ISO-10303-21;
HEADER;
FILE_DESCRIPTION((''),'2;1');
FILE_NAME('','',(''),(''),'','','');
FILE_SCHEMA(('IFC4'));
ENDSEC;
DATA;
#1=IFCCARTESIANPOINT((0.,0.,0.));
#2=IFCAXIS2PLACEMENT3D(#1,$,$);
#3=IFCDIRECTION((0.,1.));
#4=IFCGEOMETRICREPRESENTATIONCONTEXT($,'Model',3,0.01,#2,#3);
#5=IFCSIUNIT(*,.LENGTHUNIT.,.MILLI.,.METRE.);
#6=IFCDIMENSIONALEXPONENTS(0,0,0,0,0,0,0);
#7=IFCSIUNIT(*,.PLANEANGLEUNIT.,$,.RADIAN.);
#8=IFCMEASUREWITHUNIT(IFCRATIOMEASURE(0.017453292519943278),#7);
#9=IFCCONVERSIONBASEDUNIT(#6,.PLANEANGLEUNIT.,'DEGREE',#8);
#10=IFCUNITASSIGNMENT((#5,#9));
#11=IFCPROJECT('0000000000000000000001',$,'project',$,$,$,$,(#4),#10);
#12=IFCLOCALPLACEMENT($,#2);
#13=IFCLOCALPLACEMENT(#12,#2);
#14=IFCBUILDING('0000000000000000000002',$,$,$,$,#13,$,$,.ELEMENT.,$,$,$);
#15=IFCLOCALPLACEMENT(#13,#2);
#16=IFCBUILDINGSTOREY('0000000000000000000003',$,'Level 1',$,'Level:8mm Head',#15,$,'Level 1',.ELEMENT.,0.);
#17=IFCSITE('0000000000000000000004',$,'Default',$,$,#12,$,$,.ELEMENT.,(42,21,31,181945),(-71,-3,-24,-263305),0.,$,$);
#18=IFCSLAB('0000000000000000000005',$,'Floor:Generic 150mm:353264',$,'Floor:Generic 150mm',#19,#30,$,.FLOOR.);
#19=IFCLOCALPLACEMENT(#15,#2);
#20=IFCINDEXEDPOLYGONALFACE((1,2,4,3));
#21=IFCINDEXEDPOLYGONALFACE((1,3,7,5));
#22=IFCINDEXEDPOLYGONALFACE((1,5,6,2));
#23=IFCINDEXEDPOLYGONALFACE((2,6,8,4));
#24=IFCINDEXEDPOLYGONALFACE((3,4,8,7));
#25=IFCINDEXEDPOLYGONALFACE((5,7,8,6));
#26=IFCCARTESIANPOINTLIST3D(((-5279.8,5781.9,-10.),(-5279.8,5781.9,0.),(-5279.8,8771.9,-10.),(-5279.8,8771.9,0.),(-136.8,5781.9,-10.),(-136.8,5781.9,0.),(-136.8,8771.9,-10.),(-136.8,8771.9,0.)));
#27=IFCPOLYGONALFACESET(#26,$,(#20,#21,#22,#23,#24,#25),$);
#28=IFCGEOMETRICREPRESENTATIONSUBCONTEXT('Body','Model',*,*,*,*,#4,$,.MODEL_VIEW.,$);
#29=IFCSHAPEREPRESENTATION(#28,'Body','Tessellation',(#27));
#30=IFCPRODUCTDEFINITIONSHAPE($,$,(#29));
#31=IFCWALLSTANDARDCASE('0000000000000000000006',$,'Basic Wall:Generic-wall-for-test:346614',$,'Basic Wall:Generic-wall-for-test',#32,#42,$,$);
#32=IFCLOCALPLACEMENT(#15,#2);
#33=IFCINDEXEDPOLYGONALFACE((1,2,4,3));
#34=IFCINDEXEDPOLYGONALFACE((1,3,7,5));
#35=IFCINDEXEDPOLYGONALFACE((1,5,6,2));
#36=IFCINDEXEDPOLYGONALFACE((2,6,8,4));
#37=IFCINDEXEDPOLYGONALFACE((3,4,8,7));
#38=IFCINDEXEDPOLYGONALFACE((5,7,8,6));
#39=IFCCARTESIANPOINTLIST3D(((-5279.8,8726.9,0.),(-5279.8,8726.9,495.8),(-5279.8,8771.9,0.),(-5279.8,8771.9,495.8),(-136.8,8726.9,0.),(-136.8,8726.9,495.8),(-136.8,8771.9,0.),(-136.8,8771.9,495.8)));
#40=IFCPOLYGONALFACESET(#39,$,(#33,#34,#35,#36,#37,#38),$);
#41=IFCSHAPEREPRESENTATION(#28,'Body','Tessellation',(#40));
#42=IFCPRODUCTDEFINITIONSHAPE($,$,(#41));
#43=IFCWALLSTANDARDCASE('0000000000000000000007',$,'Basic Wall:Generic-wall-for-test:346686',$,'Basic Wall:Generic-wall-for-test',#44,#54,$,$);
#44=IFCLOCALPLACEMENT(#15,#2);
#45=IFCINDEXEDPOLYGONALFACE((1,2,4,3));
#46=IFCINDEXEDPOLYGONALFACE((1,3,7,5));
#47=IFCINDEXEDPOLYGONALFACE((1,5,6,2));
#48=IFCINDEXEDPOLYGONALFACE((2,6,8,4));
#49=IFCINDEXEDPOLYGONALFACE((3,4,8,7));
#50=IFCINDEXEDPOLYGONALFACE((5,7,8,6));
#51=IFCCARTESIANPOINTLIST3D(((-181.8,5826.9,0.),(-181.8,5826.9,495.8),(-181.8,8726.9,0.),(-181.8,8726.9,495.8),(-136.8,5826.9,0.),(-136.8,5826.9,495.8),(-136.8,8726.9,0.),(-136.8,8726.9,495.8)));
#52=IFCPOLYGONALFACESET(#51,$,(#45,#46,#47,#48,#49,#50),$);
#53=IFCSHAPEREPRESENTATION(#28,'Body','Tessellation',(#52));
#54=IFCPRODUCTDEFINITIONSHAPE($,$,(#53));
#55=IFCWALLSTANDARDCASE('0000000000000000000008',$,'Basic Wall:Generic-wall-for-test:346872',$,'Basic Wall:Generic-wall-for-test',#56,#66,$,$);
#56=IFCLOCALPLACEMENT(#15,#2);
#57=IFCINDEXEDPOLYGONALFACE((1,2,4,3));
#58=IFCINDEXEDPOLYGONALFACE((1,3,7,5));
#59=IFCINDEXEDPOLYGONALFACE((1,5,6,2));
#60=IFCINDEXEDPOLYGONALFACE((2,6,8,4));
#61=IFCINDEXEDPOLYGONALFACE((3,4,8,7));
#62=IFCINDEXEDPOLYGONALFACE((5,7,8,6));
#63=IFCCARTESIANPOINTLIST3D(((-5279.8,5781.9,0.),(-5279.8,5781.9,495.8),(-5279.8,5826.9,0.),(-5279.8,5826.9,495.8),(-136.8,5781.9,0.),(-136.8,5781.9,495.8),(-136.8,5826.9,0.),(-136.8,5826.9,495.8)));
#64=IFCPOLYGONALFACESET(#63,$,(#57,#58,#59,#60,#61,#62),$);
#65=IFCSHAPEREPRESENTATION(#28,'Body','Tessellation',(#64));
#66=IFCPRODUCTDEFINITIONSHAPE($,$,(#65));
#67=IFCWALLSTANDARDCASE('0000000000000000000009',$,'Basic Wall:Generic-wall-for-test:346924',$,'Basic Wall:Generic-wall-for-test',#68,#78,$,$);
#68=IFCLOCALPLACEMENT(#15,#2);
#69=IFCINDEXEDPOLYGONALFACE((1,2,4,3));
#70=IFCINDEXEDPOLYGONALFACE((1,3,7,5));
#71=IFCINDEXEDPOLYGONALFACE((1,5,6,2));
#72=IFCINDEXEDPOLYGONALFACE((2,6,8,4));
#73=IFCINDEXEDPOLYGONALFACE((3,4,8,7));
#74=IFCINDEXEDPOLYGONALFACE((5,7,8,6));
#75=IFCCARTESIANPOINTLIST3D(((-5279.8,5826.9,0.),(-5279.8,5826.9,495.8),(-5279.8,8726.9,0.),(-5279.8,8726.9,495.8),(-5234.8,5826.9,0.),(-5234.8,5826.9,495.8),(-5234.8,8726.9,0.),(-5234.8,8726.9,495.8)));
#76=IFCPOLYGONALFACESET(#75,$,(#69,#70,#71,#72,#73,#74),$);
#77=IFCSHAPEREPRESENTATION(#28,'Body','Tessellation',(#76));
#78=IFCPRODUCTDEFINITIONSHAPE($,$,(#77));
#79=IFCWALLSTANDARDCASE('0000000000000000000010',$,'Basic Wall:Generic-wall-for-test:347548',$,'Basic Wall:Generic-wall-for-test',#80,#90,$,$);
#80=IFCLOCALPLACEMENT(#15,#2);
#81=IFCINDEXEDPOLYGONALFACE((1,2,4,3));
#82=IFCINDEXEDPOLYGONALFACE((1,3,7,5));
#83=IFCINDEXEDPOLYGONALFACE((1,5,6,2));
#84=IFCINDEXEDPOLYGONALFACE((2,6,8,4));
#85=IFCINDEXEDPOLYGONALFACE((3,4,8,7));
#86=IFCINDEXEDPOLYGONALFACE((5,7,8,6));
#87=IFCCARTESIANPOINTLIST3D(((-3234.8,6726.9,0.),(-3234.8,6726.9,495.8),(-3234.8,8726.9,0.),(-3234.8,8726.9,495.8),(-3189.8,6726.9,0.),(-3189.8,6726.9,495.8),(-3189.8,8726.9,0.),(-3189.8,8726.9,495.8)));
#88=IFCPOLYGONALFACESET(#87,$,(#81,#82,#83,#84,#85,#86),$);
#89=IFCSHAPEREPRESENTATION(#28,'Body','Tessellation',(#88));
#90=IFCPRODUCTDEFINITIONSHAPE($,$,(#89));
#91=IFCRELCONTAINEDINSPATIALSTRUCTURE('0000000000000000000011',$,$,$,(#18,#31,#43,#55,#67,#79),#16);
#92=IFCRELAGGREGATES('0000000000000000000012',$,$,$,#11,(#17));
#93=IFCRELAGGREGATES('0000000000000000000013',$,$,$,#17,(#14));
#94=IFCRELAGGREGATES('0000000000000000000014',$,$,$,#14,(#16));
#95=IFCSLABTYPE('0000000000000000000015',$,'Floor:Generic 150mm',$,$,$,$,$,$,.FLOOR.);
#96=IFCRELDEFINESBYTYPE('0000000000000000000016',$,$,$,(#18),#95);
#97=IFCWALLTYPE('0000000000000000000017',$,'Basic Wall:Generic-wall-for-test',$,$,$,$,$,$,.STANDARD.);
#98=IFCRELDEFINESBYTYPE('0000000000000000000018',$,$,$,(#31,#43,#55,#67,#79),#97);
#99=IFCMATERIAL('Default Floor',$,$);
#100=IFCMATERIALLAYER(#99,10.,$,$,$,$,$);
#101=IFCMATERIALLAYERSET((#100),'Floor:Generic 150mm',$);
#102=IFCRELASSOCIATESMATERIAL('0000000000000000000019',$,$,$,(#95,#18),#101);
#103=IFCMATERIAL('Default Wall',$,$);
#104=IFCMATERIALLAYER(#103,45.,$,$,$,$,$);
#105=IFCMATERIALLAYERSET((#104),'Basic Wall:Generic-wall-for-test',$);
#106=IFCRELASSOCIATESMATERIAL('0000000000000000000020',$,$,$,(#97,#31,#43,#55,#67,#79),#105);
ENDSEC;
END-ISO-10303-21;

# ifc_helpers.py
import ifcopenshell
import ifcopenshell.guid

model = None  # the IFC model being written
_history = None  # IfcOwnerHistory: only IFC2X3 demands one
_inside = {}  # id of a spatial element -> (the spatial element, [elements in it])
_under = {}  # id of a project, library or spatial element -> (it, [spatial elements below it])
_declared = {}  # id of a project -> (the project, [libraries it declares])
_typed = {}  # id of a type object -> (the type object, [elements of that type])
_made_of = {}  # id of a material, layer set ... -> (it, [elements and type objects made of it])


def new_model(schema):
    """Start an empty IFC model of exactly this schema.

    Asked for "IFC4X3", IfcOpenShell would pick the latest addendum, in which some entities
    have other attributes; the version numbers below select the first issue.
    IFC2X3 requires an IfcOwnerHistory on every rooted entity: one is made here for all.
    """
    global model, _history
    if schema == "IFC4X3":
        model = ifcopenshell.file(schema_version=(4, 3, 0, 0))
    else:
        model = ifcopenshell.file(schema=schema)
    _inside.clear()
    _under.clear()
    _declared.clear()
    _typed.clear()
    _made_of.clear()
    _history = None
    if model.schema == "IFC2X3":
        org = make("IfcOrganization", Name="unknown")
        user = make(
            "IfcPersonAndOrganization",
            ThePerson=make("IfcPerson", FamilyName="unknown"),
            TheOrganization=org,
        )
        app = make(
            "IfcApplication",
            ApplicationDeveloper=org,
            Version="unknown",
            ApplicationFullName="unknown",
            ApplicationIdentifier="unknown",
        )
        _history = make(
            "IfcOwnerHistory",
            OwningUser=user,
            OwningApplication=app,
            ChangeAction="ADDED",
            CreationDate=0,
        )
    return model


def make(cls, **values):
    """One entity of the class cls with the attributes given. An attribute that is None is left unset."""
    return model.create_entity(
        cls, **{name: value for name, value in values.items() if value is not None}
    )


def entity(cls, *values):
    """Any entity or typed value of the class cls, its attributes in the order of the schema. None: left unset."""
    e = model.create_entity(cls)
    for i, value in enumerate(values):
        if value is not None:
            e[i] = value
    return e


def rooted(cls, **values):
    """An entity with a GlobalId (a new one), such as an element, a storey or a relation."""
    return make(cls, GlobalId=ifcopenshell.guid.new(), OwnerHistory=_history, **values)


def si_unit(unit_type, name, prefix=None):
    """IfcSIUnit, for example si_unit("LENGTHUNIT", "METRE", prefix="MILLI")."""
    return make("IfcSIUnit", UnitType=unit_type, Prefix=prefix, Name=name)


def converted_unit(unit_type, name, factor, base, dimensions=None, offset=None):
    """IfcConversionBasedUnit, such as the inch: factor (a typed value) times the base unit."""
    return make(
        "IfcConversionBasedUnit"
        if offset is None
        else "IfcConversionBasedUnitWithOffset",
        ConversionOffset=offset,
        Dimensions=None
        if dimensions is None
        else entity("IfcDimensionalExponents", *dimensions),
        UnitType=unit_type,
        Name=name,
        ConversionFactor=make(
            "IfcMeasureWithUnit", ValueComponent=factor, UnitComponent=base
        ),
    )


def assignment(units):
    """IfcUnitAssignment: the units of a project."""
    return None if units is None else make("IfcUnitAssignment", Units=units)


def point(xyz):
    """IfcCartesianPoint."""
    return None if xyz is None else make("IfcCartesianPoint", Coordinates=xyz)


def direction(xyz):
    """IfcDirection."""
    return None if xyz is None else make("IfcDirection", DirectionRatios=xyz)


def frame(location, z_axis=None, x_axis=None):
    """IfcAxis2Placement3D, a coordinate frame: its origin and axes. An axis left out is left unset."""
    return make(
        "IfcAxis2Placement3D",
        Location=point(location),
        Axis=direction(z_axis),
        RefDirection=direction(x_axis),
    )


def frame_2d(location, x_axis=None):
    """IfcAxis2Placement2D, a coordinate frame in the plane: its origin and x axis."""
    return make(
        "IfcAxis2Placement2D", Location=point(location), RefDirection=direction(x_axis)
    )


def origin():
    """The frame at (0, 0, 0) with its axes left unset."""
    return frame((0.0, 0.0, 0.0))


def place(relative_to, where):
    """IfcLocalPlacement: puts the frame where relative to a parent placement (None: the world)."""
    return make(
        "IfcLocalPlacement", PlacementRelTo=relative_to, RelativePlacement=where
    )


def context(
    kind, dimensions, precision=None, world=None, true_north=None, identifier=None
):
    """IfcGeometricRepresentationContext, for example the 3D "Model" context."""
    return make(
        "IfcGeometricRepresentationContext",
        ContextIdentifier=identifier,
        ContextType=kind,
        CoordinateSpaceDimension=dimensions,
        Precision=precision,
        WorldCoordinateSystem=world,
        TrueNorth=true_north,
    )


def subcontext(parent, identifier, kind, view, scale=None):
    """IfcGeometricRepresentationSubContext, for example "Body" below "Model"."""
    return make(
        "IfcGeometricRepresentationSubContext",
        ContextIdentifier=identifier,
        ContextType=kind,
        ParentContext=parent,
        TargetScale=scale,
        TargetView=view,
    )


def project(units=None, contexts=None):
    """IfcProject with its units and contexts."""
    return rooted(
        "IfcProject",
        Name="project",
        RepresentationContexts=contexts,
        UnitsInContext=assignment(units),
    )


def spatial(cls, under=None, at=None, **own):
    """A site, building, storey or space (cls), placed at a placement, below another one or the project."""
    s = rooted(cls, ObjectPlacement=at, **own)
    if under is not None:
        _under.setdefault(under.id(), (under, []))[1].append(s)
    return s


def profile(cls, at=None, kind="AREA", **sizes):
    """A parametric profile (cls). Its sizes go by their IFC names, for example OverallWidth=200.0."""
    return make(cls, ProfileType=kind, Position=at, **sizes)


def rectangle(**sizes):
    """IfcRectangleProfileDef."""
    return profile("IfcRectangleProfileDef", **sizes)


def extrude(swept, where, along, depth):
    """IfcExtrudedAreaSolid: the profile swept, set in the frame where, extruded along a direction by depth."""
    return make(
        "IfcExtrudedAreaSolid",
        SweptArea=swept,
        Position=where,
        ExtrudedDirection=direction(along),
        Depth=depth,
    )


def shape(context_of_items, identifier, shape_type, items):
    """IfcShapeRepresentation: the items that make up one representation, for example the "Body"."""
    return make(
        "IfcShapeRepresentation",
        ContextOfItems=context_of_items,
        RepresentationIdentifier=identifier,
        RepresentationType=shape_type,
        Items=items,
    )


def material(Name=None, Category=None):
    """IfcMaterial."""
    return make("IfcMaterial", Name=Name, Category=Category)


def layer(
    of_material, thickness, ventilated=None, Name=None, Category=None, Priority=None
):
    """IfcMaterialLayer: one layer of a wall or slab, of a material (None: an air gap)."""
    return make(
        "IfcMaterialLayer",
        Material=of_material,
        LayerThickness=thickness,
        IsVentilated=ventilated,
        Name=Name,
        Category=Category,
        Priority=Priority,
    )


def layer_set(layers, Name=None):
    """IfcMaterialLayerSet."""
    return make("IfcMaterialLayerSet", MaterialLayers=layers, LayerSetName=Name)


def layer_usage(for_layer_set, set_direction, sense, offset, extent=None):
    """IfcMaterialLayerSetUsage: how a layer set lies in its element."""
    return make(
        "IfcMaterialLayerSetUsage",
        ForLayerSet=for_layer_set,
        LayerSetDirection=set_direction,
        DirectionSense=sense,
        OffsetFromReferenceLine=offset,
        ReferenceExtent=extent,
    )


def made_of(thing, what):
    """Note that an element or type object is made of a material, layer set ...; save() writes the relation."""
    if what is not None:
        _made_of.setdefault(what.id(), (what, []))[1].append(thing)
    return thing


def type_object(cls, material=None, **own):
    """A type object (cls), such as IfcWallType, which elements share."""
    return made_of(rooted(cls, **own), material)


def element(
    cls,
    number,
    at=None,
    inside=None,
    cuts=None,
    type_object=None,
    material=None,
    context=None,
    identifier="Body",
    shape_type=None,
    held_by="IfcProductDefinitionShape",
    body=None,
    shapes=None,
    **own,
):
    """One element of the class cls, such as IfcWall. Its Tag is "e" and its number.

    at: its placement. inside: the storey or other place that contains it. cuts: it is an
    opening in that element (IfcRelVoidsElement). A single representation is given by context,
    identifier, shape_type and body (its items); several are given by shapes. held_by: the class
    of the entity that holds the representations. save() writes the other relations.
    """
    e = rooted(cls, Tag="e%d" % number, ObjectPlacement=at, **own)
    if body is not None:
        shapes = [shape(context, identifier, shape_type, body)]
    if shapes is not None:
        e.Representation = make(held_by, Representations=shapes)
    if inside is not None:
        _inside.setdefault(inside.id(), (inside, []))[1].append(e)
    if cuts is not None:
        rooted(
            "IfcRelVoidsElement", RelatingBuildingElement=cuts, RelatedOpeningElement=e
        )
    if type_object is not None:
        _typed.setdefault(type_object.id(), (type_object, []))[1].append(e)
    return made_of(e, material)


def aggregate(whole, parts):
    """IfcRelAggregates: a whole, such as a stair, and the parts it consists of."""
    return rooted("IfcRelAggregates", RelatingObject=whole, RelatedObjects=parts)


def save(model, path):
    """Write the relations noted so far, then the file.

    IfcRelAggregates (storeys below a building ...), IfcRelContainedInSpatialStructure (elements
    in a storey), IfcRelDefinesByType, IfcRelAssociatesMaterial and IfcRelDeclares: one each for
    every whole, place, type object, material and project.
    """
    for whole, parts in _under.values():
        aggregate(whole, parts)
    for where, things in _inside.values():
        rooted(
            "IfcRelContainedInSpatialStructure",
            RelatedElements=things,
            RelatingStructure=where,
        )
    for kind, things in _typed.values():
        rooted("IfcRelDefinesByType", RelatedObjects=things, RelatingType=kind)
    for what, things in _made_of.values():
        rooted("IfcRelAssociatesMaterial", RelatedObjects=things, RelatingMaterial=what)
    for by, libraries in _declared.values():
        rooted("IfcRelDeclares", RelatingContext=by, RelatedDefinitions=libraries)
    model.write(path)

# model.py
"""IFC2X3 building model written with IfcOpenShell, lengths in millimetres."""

from ifc_helpers import new_model, entity, si_unit, converted_unit, direction, frame, frame_2d, origin, place, context, subcontext, project, spatial, rectangle, extrude, material, layer, layer_set, layer_usage, type_object, element, save


model = new_model("IFC2X3")

# Units and contexts
model_context = context("Model", 3, precision=0.01, world=origin(), true_north=direction((0.0, 1.0)))
body_context = subcontext(model_context, "Body", "Model", "MODEL_VIEW")
ifc_project = project(units=[si_unit("LENGTHUNIT", "METRE", prefix="MILLI"), converted_unit("PLANEANGLEUNIT", "DEGREE", entity("IfcRatioMeasure", 0.017453292519943278), si_unit("PLANEANGLEUNIT", "RADIAN"), dimensions=[0, 0, 0, 0, 0, 0, 0])], contexts=[model_context])

# Site, building, storey
site_placement = place(None, origin())
site = spatial("IfcSite", under=ifc_project, at=site_placement, Name="Default", CompositionType="ELEMENT", RefLatitude=(42, 21, 31, 181945), RefLongitude=(-71, -3, -24, -263305), RefElevation=0.0)
building_placement = place(site_placement, origin())
building = spatial("IfcBuilding", under=site, at=building_placement, CompositionType="ELEMENT")
storey_placement = place(building_placement, origin())
storey = spatial("IfcBuildingStorey", under=building, at=storey_placement, Name="Level 1", ObjectType="Level:8mm Head", LongName="Level 1", CompositionType="ELEMENT", Elevation=0.0)

# Slab
ifc_material_1 = material(Name="Default Floor")
ifc_layer_1 = layer(ifc_material_1, 10.0)
ifc_layer_set_1 = layer_set([ifc_layer_1], Name="Floor:Generic 150mm")
ifc_layer_usage_1 = layer_usage(ifc_layer_set_1, "AXIS3", "POSITIVE", 0.0)
slab_type = type_object("IfcSlabType", Name="Floor:Generic 150mm", PredefinedType="FLOOR", material=ifc_layer_set_1)
slab_placement = place(storey_placement, origin())
element("IfcSlab", 1, at=slab_placement, inside=storey, type_object=slab_type, material=ifc_layer_usage_1, Name="Floor:Generic 150mm:353264", ObjectType="Floor:Generic 150mm", PredefinedType="FLOOR", context=body_context, shape_type="SweptSolid", body=[
    extrude(rectangle(XDim=2990.0, YDim=5143.0, at=frame_2d((0.0, 0.0), x_axis=(1.0, 0.0))), frame((-2708.3, 7276.9, 0.0), z_axis=(0.0, 0.0, -1.0), x_axis=(0.0, 1.0, 0.0)), (0.0, 0.0, 1.0), 10.0),
])

# Walls
ifc_material_2 = material(Name="Default Wall")
ifc_layer_2 = layer(ifc_material_2, 45.0)
ifc_layer_set_2 = layer_set([ifc_layer_2], Name="Basic Wall:Generic-wall-for-test")
ifc_layer_usage_2 = layer_usage(ifc_layer_set_2, "AXIS2", "NEGATIVE", 22.5)
wall_type = type_object("IfcWallType", Name="Basic Wall:Generic-wall-for-test", PredefinedType="STANDARD", material=ifc_layer_set_2)
wall_1_placement = place(storey_placement, frame((-5279.8, 8749.4, 0.0)))
element("IfcWallStandardCase", 2, at=wall_1_placement, inside=storey, type_object=wall_type, material=ifc_layer_usage_2, Name="Basic Wall:Generic-wall-for-test:346614", ObjectType="Basic Wall:Generic-wall-for-test", context=body_context, shape_type="SweptSolid", body=[
    extrude(rectangle(XDim=5143.0, YDim=45.0, at=frame_2d((2571.5, 0.0), x_axis=(-1.0, 0.0))), origin(), (0.0, 0.0, 1.0), 495.8),
])
wall_2_placement = place(storey_placement, frame((-159.3, 8726.9, 0.0), z_axis=(0.0, 0.0, 1.0), x_axis=(0.0, -1.0, 0.0)))
element("IfcWallStandardCase", 3, at=wall_2_placement, inside=storey, type_object=wall_type, material=ifc_layer_usage_2, Name="Basic Wall:Generic-wall-for-test:346686", ObjectType="Basic Wall:Generic-wall-for-test", context=body_context, shape_type="SweptSolid", body=[
    extrude(rectangle(XDim=2900.0, YDim=45.0, at=frame_2d((1450.0, 0.0), x_axis=(-1.0, 0.0))), origin(), (0.0, 0.0, 1.0), 495.8),
])
wall_3_placement = place(storey_placement, frame((-136.8, 5804.4, 0.0), z_axis=(0.0, 0.0, 1.0), x_axis=(-1.0, 0.0, 0.0)))
element("IfcWallStandardCase", 4, at=wall_3_placement, inside=storey, type_object=wall_type, material=ifc_layer_usage_2, Name="Basic Wall:Generic-wall-for-test:346872", ObjectType="Basic Wall:Generic-wall-for-test", context=body_context, shape_type="SweptSolid", body=[
    extrude(rectangle(XDim=5143.0, YDim=45.0, at=frame_2d((2571.5, 0.0), x_axis=(-1.0, 0.0))), origin(), (0.0, 0.0, 1.0), 495.8),
])
wall_4_placement = place(storey_placement, frame((-5257.3, 5826.9, 0.0), z_axis=(0.0, 0.0, 1.0), x_axis=(0.0, 1.0, 0.0)))
element("IfcWallStandardCase", 5, at=wall_4_placement, inside=storey, type_object=wall_type, material=ifc_layer_usage_2, Name="Basic Wall:Generic-wall-for-test:346924", ObjectType="Basic Wall:Generic-wall-for-test", context=body_context, shape_type="SweptSolid", body=[
    extrude(rectangle(XDim=2900.0, YDim=45.0, at=frame_2d((1450.0, 0.0), x_axis=(-1.0, 0.0))), origin(), (0.0, 0.0, 1.0), 495.8),
])
wall_5_placement = place(storey_placement, frame((-3212.3, 8726.9, 0.0), z_axis=(0.0, 0.0, 1.0), x_axis=(0.0, -1.0, 0.0)))
element("IfcWallStandardCase", 6, at=wall_5_placement, inside=storey, type_object=wall_type, material=ifc_layer_usage_2, Name="Basic Wall:Generic-wall-for-test:347548", ObjectType="Basic Wall:Generic-wall-for-test", context=body_context, shape_type="SweptSolid", body=[
    extrude(rectangle(XDim=2000.0, YDim=45.0, at=frame_2d((1000.0, 0.0), x_axis=(-1.0, 0.0))), origin(), (0.0, 0.0, 1.0), 495.8),
])

save(model, "model.ifc")
